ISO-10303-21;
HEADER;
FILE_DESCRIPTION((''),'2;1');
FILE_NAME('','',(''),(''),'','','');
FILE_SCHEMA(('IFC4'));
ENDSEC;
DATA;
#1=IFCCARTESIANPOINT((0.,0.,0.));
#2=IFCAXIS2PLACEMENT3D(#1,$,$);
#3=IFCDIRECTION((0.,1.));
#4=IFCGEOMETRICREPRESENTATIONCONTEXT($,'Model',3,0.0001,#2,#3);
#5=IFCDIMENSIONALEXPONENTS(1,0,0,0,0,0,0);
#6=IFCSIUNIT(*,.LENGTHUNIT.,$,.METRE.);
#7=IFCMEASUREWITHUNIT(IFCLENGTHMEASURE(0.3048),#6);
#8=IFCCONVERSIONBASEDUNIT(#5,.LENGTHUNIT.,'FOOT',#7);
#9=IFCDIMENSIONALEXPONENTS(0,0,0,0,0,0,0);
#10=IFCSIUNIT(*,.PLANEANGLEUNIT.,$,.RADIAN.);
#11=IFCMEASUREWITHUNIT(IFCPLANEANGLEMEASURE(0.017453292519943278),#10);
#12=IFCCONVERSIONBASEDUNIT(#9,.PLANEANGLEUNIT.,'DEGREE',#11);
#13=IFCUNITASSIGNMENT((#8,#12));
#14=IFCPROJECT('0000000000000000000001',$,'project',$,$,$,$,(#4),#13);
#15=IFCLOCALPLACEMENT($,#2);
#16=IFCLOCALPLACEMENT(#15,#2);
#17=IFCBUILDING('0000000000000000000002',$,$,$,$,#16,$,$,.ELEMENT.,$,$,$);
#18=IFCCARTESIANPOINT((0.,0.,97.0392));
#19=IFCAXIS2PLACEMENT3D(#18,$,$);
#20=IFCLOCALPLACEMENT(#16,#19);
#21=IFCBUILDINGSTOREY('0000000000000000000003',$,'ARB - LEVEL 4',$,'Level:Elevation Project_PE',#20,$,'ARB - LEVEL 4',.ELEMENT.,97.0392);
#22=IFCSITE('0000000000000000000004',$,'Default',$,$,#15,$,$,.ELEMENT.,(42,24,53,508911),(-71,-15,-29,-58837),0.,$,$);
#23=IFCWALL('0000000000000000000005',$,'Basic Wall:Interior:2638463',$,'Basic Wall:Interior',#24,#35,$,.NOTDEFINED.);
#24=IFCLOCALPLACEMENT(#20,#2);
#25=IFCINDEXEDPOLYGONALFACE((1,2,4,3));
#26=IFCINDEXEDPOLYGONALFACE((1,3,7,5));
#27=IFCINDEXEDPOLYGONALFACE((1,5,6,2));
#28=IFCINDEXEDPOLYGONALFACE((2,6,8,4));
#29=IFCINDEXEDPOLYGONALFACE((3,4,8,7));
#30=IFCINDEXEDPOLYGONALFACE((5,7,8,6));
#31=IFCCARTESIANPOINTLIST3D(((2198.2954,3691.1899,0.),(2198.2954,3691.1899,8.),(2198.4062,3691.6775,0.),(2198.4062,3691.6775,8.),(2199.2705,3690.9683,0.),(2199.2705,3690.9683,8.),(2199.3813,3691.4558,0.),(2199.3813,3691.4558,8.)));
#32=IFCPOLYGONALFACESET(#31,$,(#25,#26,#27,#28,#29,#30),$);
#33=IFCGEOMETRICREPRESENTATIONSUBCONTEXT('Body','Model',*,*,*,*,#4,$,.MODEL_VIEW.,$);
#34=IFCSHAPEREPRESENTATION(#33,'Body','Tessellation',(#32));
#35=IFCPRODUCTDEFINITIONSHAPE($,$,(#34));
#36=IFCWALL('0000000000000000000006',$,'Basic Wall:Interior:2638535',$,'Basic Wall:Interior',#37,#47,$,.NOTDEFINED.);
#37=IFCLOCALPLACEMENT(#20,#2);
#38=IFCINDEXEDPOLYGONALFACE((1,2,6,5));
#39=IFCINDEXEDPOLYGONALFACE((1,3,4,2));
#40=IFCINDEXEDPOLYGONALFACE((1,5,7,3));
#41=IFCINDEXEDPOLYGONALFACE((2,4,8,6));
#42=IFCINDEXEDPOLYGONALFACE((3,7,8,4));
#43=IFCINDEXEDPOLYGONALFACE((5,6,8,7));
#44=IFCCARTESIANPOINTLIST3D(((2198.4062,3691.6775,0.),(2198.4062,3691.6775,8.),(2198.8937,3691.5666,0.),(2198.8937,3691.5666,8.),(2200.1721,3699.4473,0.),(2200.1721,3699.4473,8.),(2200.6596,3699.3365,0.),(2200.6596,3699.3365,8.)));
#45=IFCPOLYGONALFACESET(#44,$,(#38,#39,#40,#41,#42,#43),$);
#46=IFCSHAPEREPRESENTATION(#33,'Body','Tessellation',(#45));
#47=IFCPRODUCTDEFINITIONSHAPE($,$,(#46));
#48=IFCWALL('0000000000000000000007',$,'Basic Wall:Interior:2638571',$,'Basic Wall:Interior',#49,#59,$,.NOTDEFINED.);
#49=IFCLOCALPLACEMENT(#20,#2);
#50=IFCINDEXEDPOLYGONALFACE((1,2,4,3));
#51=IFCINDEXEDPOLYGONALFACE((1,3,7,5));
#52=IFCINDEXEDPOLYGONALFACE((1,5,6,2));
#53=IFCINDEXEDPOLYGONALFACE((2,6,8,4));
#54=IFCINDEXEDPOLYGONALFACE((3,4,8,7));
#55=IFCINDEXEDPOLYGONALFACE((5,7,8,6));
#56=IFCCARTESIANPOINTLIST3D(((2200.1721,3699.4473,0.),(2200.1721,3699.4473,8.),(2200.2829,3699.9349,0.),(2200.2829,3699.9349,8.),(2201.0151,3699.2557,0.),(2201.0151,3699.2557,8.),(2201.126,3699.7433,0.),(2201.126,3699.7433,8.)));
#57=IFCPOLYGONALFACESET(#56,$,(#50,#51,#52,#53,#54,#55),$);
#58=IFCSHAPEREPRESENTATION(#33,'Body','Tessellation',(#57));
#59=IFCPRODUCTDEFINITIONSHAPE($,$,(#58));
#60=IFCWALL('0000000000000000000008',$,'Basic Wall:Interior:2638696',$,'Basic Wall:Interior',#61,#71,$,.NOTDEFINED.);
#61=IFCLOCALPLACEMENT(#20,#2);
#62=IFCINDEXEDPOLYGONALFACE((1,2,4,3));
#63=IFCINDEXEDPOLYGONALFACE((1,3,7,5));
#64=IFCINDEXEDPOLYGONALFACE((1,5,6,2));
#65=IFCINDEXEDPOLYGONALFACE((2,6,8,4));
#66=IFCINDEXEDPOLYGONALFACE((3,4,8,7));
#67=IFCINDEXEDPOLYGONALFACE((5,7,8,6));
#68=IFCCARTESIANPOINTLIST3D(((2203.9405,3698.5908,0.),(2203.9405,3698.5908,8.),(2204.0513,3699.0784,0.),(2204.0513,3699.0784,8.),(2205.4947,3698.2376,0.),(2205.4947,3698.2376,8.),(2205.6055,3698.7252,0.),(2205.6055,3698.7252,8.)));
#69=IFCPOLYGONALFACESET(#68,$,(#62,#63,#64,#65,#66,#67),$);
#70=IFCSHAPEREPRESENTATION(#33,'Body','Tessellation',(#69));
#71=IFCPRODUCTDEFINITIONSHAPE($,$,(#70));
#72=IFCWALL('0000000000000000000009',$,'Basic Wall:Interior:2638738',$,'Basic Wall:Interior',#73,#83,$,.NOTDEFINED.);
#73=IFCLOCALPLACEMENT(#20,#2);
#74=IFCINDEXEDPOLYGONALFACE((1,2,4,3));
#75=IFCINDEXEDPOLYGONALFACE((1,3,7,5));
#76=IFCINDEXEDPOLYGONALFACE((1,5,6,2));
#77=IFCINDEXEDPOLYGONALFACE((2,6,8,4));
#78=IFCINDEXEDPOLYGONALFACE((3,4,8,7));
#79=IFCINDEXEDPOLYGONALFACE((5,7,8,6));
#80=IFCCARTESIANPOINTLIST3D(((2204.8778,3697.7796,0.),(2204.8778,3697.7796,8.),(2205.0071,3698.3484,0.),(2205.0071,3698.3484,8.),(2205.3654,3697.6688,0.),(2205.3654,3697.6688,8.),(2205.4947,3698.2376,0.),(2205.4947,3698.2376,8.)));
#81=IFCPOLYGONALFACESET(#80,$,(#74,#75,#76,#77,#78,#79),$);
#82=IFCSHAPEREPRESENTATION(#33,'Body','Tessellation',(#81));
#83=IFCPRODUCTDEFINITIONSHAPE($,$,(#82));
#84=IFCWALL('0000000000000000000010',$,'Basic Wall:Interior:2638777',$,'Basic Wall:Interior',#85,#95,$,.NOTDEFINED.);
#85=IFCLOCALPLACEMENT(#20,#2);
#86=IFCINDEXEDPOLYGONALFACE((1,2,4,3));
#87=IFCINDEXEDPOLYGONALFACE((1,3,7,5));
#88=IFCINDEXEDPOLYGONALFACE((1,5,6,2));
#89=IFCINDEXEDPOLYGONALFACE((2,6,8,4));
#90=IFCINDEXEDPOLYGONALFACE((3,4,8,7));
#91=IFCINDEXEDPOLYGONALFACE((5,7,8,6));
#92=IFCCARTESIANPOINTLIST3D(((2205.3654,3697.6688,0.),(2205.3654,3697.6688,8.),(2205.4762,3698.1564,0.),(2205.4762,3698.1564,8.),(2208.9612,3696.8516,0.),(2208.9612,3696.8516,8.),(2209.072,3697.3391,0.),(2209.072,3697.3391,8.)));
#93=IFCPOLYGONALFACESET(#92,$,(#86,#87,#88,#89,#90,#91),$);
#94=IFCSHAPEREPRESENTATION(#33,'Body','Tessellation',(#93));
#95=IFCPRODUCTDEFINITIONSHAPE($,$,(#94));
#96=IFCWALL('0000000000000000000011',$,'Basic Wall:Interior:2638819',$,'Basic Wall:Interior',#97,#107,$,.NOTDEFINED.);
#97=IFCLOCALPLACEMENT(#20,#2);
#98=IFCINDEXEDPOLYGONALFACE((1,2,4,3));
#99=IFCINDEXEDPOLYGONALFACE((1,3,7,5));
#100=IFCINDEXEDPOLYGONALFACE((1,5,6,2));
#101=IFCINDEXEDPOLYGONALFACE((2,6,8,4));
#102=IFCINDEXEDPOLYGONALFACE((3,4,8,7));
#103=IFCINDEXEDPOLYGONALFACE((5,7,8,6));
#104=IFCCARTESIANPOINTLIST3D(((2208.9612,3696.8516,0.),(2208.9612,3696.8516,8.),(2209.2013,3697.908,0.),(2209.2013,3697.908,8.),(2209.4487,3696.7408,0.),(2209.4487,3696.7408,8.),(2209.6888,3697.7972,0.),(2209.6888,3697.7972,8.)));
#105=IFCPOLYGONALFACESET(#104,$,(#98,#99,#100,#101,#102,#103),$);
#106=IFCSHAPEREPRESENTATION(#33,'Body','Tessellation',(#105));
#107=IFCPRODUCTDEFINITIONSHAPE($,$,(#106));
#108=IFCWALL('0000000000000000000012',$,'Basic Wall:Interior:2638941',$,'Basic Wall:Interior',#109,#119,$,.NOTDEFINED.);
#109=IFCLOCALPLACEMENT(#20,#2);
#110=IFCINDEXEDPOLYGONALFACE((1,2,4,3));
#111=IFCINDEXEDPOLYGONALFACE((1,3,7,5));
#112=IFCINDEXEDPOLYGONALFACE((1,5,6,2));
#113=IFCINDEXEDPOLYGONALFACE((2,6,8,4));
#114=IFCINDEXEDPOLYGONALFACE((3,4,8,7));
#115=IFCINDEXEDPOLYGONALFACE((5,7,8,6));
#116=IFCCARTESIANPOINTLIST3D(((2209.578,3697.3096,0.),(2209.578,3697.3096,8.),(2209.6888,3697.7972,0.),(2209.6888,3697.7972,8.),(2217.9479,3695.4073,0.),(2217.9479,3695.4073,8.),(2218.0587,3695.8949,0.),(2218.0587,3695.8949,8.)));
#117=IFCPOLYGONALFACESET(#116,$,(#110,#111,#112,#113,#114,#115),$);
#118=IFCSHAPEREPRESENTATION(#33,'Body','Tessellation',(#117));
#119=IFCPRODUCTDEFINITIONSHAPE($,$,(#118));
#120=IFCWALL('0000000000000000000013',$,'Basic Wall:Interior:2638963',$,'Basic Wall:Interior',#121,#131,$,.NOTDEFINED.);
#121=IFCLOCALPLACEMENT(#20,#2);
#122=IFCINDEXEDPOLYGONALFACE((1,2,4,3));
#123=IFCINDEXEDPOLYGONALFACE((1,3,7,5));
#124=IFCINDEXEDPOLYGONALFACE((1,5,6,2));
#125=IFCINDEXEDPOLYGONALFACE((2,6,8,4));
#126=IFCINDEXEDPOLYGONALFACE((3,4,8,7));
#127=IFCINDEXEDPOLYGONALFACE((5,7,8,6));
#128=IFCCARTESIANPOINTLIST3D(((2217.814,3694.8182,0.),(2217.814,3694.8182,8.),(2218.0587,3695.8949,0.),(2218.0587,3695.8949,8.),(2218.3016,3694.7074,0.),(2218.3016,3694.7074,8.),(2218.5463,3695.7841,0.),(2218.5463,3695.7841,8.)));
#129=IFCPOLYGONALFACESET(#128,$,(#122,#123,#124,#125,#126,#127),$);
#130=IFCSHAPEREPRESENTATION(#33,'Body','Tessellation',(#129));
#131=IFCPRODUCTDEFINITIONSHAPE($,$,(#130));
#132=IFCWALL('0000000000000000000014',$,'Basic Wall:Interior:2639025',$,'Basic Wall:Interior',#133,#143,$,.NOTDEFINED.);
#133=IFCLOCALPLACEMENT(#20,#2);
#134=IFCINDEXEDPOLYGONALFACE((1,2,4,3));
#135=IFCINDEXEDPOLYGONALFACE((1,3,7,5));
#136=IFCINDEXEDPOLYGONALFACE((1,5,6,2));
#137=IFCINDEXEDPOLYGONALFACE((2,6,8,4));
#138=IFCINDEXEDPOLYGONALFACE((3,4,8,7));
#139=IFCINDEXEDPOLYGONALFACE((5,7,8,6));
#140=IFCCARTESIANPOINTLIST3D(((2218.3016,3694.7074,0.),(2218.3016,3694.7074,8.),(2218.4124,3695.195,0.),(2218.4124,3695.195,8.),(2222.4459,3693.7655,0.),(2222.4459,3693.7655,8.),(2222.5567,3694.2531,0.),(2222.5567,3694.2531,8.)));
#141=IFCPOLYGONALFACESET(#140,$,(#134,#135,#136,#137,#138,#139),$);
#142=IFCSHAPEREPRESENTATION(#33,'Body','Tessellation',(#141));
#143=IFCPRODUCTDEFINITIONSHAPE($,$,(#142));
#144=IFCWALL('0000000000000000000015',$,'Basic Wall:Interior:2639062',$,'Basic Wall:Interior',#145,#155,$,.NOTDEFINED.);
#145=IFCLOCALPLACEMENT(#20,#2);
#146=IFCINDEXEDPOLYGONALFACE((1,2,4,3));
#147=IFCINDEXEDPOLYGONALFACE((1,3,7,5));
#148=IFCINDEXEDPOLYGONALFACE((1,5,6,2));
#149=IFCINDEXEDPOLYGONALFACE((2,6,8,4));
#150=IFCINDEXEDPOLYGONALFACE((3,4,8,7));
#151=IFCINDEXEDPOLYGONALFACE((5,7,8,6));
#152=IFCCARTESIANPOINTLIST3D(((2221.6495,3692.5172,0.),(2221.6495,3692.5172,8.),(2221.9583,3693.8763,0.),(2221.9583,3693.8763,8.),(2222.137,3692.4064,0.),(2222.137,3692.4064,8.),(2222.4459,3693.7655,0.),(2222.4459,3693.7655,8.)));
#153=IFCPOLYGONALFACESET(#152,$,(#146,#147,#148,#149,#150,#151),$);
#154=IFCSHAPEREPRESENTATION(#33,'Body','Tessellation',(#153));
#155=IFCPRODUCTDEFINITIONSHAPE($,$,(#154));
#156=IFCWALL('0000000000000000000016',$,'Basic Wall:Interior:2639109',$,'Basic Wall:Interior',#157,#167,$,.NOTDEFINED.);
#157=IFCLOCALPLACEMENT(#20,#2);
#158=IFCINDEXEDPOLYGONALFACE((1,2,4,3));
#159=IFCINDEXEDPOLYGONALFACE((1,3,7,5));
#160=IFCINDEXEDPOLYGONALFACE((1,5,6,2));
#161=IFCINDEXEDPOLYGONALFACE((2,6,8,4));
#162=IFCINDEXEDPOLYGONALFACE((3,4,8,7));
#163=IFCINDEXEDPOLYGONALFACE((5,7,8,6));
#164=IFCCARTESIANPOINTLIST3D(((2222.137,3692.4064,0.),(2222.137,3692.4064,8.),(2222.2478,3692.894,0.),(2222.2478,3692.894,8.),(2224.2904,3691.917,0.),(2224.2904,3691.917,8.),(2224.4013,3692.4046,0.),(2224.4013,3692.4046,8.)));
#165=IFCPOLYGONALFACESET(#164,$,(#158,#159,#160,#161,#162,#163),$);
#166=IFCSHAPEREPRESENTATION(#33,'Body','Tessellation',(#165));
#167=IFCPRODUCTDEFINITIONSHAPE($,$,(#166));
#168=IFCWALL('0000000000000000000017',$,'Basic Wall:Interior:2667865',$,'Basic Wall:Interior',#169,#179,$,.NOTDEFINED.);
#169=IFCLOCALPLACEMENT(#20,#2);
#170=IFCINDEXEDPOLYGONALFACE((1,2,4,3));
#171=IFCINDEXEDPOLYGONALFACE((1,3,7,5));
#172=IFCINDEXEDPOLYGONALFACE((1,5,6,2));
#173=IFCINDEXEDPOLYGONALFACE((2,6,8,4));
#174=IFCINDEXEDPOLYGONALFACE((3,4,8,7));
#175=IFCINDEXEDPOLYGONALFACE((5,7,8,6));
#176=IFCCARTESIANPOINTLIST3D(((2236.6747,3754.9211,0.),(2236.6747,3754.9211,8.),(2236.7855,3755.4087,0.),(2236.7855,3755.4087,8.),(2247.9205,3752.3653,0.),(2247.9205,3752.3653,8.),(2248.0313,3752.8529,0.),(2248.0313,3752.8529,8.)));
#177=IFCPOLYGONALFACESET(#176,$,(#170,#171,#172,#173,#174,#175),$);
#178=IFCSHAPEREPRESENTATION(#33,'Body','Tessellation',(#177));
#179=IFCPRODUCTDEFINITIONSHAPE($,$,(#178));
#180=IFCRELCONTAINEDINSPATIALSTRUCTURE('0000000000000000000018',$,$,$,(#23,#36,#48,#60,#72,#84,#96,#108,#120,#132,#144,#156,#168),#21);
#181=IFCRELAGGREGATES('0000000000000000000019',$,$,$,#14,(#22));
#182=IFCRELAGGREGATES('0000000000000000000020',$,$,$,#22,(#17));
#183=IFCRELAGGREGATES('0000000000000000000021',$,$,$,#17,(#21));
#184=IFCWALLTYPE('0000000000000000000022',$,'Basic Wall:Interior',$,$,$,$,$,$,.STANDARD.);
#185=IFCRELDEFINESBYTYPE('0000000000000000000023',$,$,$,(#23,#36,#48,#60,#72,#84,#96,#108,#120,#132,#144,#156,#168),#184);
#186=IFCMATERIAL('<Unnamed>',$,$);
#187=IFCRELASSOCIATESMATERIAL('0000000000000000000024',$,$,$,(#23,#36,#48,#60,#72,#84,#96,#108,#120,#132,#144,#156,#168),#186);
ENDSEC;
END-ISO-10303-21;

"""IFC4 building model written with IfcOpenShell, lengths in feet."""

from ifc_helpers import new_model, entity, si_unit, converted_unit, direction, frame, origin, place, context, subcontext, project, spatial, indexed_curve, outline, extrude, material, type_object, element, save


model = new_model("IFC4")

# Units and contexts
model_context = context("Model", 3, precision=0.0001, world=origin(), true_north=direction((0.0, 1.0)))
body_context = subcontext(model_context, "Body", "Model", "MODEL_VIEW")
ifc_project = project(units=[converted_unit("LENGTHUNIT", "FOOT", entity("IfcLengthMeasure", 0.3048), si_unit("LENGTHUNIT", "METRE"), dimensions=[1, 0, 0, 0, 0, 0, 0]), converted_unit("PLANEANGLEUNIT", "DEGREE", entity("IfcPlaneAngleMeasure", 0.017453292519943278), si_unit("PLANEANGLEUNIT", "RADIAN"), dimensions=[0, 0, 0, 0, 0, 0, 0])], contexts=[model_context])

# Site, building, storey
site_placement = place(None, origin())
site = spatial("IfcSite", under=ifc_project, at=site_placement, Name="Default", CompositionType="ELEMENT", RefLatitude=(42, 24, 53, 508911), RefLongitude=(-71, -15, -29, -58837), RefElevation=0.0)
building_placement = place(site_placement, origin())
building = spatial("IfcBuilding", under=site, at=building_placement, CompositionType="ELEMENT")
storey_placement = place(building_placement, frame((0.0, 0.0, 97.0392)))
storey = spatial("IfcBuildingStorey", under=building, at=storey_placement, Name="ARB - LEVEL 4", ObjectType="Level:Elevation Project_PE", LongName="ARB - LEVEL 4", CompositionType="ELEMENT", Elevation=97.0392)

# Walls
ifc_material_1 = material(Name="<Unnamed>")
wall_type = type_object("IfcWallType", Name="Basic Wall:Interior", PredefinedType="STANDARD")
wall_1_placement = place(storey_placement, frame((2199.3259, 3691.212, 0.0), z_axis=(0.0, 0.0, 1.0), x_axis=(-0.975133, 0.221622, 0.0)))
element("IfcWall", 1, at=wall_1_placement, inside=storey, type_object=wall_type, material=ifc_material_1, Name="Basic Wall:Interior:2638463", ObjectType="Basic Wall:Interior", PredefinedType="NOTDEFINED", context=body_context, shape_type="SweptSolid", body=[
    extrude(outline(indexed_curve([(1.0, 0.25), (0.0, 0.25), (0.0, -0.25), (1.0, -0.25), (1.0, 0.25)], self_intersect=False)), origin(), (0.0, 0.0, 1.0), 8.0),
])
wall_2_placement = place(storey_placement, frame((2198.65, 3691.622, 0.0), z_axis=(0.0, 0.0, 1.0), x_axis=(0.221622, 0.975133, 0.0)))
element("IfcWall", 2, at=wall_2_placement, inside=storey, type_object=wall_type, material=ifc_material_1, Name="Basic Wall:Interior:2638535", ObjectType="Basic Wall:Interior", PredefinedType="NOTDEFINED", context=body_context, shape_type="SweptSolid", body=[
    extrude(outline(indexed_curve([(7.968, 0.25), (0.0, 0.25), (0.0, -0.25), (7.968, -0.25), (7.968, 0.25)], self_intersect=False)), origin(), (0.0, 0.0, 1.0), 8.0),
])
wall_3_placement = place(storey_placement, frame((2200.2275, 3699.6911, 0.0), z_axis=(0.0, 0.0, 1.0), x_axis=(0.975133, -0.221622, 0.0)))
element("IfcWall", 3, at=wall_3_placement, inside=storey, type_object=wall_type, material=ifc_material_1, Name="Basic Wall:Interior:2638571", ObjectType="Basic Wall:Interior", PredefinedType="NOTDEFINED", context=body_context, shape_type="SweptSolid", body=[
    extrude(outline(indexed_curve([(0.8646, 0.25), (0.0, 0.25), (0.0, -0.25), (0.8646, -0.25), (0.8646, 0.25)], self_intersect=False)), origin(), (0.0, 0.0, 1.0), 8.0),
])
wall_4_placement = place(storey_placement, frame((2203.9959, 3698.8346, 0.0), z_axis=(0.0, 0.0, 1.0), x_axis=(0.975133, -0.221622, 0.0)))
element("IfcWall", 4, at=wall_4_placement, inside=storey, type_object=wall_type, material=ifc_material_1, Name="Basic Wall:Interior:2638696", ObjectType="Basic Wall:Interior", PredefinedType="NOTDEFINED", context=body_context, shape_type="SweptSolid", body=[
    extrude(outline(indexed_curve([(1.5938, 0.25), (0.0, 0.25), (0.0, -0.25), (1.5938, -0.25), (1.5938, 0.25)], self_intersect=False)), origin(), (0.0, 0.0, 1.0), 8.0),
])
wall_5_placement = place(storey_placement, frame((2205.2509, 3698.293, 0.0), z_axis=(0.0, 0.0, 1.0), x_axis=(-0.221622, -0.975133, 0.0)))
element("IfcWall", 5, at=wall_5_placement, inside=storey, type_object=wall_type, material=ifc_material_1, Name="Basic Wall:Interior:2638738", ObjectType="Basic Wall:Interior", PredefinedType="NOTDEFINED", context=body_context, shape_type="SweptSolid", body=[
    extrude(outline(indexed_curve([(0.5833, 0.25), (0.0, 0.25), (0.0, -0.25), (0.5833, -0.25), (0.5833, 0.25)], self_intersect=False)), origin(), (0.0, 0.0, 1.0), 8.0),
])
wall_6_placement = place(storey_placement, frame((2205.4208, 3697.9126, 0.0), z_axis=(0.0, 0.0, 1.0), x_axis=(0.975133, -0.221622, 0.0)))
element("IfcWall", 6, at=wall_6_placement, inside=storey, type_object=wall_type, material=ifc_material_1, Name="Basic Wall:Interior:2638777", ObjectType="Basic Wall:Interior", PredefinedType="NOTDEFINED", context=body_context, shape_type="SweptSolid", body=[
    extrude(outline(indexed_curve([(3.6875, 0.25), (0.0, 0.25), (0.0, -0.25), (3.6875, -0.25), (3.6875, 0.25)], self_intersect=False)), origin(), (0.0, 0.0, 1.0), 8.0),
])
wall_7_placement = place(storey_placement, frame((2209.205, 3696.7962, 0.0), z_axis=(0.0, 0.0, 1.0), x_axis=(0.221622, 0.975133, 0.0)))
element("IfcWall", 7, at=wall_7_placement, inside=storey, type_object=wall_type, material=ifc_material_1, Name="Basic Wall:Interior:2638819", ObjectType="Basic Wall:Interior", PredefinedType="NOTDEFINED", context=body_context, shape_type="SweptSolid", body=[
    extrude(outline(indexed_curve([(1.0833, 0.25), (0.0, 0.25), (0.0, -0.25), (1.0833, -0.25), (1.0833, 0.25)], self_intersect=False)), origin(), (0.0, 0.0, 1.0), 8.0),
])
wall_8_placement = place(storey_placement, frame((2209.6334, 3697.5534, 0.0), z_axis=(0.0, 0.0, 1.0), x_axis=(0.975133, -0.221622, 0.0)))
element("IfcWall", 8, at=wall_8_placement, inside=storey, type_object=wall_type, material=ifc_material_1, Name="Basic Wall:Interior:2638941", ObjectType="Basic Wall:Interior", PredefinedType="NOTDEFINED", context=body_context, shape_type="SweptSolid", body=[
    extrude(outline(indexed_curve([(8.5833, 0.25), (0.0, 0.25), (0.0, -0.25), (8.5833, -0.25), (8.5833, 0.25)], self_intersect=False)), origin(), (0.0, 0.0, 1.0), 8.0),
])
wall_9_placement = place(storey_placement, frame((2218.3025, 3695.8395, 0.0), z_axis=(0.0, 0.0, 1.0), x_axis=(-0.221622, -0.975133, 0.0)))
element("IfcWall", 9, at=wall_9_placement, inside=storey, type_object=wall_type, material=ifc_material_1, Name="Basic Wall:Interior:2638963", ObjectType="Basic Wall:Interior", PredefinedType="NOTDEFINED", context=body_context, shape_type="SweptSolid", body=[
    extrude(outline(indexed_curve([(1.1042, 0.25), (0.0, 0.25), (0.0, -0.25), (1.1042, -0.25), (1.1042, 0.25)], self_intersect=False)), origin(), (0.0, 0.0, 1.0), 8.0),
])
wall_10_placement = place(storey_placement, frame((2218.357, 3694.9512, 0.0), z_axis=(0.0, 0.0, 1.0), x_axis=(0.975133, -0.221622, 0.0)))
element("IfcWall", 10, at=wall_10_placement, inside=storey, type_object=wall_type, material=ifc_material_1, Name="Basic Wall:Interior:2639025", ObjectType="Basic Wall:Interior", PredefinedType="NOTDEFINED", context=body_context, shape_type="SweptSolid", body=[
    extrude(outline(indexed_curve([(4.25, 0.25), (0.0, 0.25), (0.0, -0.25), (4.25, -0.25), (4.25, 0.25)], self_intersect=False)), origin(), (0.0, 0.0, 1.0), 8.0),
])
wall_11_placement = place(storey_placement, frame((2222.2021, 3693.8209, 0.0), z_axis=(0.0, 0.0, 1.0), x_axis=(-0.221622, -0.975133, 0.0)))
element("IfcWall", 11, at=wall_11_placement, inside=storey, type_object=wall_type, material=ifc_material_1, Name="Basic Wall:Interior:2639062", ObjectType="Basic Wall:Interior", PredefinedType="NOTDEFINED", context=body_context, shape_type="SweptSolid", body=[
    extrude(outline(indexed_curve([(1.3937, 0.25), (0.0, 0.25), (0.0, -0.25), (1.3937, -0.25), (1.3937, 0.25)], self_intersect=False)), origin(), (0.0, 0.0, 1.0), 8.0),
])
wall_12_placement = place(storey_placement, frame((2222.1924, 3692.6502, 0.0), z_axis=(0.0, 0.0, 1.0), x_axis=(0.975133, -0.221622, 0.0)))
element("IfcWall", 12, at=wall_12_placement, inside=storey, type_object=wall_type, material=ifc_material_1, Name="Basic Wall:Interior:2639109", ObjectType="Basic Wall:Interior", PredefinedType="NOTDEFINED", context=body_context, shape_type="SweptSolid", body=[
    extrude(outline(indexed_curve([(2.2083, 0.25), (0.0, 0.25), (0.0, -0.25), (2.2083, -0.25), (2.2083, 0.25)], self_intersect=False)), origin(), (0.0, 0.0, 1.0), 8.0),
])
wall_13_placement = place(storey_placement, frame((2247.9759, 3752.6091, 0.0), z_axis=(0.0, 0.0, 1.0), x_axis=(-0.975133, 0.221622, 0.0)))
element("IfcWall", 13, at=wall_13_placement, inside=storey, type_object=wall_type, material=ifc_material_1, Name="Basic Wall:Interior:2667865", ObjectType="Basic Wall:Interior", PredefinedType="NOTDEFINED", context=body_context, shape_type="SweptSolid", body=[
    extrude(outline(indexed_curve([(11.5325, 0.25), (0.0, 0.25), (0.0, -0.25), (11.5325, -0.25), (11.5325, 0.25)], self_intersect=False)), origin(), (0.0, 0.0, 1.0), 8.0),
])

save(model, "model.ifc")
